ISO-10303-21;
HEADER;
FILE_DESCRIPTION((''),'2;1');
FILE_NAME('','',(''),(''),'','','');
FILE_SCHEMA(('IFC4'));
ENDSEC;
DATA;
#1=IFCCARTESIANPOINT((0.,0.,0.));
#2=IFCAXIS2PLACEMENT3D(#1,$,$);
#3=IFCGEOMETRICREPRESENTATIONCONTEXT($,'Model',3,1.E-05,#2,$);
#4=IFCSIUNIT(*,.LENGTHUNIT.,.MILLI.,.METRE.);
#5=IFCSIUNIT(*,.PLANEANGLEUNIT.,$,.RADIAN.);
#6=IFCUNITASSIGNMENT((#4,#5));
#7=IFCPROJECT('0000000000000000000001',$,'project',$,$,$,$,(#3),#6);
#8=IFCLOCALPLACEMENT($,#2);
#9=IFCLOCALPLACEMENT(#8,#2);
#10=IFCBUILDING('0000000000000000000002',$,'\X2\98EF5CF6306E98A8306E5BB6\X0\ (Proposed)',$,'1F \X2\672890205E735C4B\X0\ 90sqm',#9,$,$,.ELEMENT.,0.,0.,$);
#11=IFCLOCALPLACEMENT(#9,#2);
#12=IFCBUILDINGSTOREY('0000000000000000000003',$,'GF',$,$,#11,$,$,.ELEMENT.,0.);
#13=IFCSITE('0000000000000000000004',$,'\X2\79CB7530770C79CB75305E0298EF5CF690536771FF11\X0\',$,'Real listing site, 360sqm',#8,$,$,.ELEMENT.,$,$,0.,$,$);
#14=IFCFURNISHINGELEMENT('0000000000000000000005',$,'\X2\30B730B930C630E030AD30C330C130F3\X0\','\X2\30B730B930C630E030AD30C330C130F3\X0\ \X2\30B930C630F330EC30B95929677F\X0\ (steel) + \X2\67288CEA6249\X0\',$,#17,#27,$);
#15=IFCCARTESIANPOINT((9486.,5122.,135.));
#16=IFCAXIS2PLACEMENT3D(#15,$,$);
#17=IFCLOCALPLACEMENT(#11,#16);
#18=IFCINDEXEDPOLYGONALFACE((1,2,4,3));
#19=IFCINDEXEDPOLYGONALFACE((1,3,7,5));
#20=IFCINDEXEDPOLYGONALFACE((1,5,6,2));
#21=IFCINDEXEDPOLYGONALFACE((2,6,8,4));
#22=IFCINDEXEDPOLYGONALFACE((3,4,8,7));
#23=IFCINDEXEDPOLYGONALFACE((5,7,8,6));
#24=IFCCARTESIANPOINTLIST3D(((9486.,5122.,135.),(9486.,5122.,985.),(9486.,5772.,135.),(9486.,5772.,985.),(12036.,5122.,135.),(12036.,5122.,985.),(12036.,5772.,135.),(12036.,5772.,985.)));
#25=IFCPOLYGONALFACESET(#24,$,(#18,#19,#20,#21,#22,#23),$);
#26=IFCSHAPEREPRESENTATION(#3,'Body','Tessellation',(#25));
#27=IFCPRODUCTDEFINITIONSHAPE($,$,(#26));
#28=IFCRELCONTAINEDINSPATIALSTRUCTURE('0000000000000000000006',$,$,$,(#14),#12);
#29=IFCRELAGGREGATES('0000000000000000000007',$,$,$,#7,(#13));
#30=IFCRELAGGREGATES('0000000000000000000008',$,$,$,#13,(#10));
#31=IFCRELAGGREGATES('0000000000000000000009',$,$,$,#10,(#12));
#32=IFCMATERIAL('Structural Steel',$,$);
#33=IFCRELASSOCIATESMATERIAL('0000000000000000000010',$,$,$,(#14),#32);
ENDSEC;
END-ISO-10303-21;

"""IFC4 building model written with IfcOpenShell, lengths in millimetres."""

from ifc_helpers import new_model, si_unit, frame, frame_2d, origin, place, context, project, spatial, rectangle, extrude, material, element, save


model = new_model("IFC4")

# Units and contexts
model_context = context("Model", 3, precision=1e-05, world=origin())
ifc_project = project(units=[si_unit("LENGTHUNIT", "METRE", prefix="MILLI"), si_unit("PLANEANGLEUNIT", "RADIAN")], contexts=[model_context])

# Site, building, storey
site_placement = place(None, origin())
site = spatial("IfcSite", under=ifc_project, at=site_placement, Name="秋田県秋田市飯島道東１", ObjectType="Real listing site, 360sqm", CompositionType="ELEMENT", RefElevation=0.0)
building_placement = place(site_placement, origin())
building = spatial("IfcBuilding", under=site, at=building_placement, Name="飯島の風の家 (Proposed)", ObjectType="1F 木造平屋 90sqm", CompositionType="ELEMENT", ElevationOfRefHeight=0.0, ElevationOfTerrain=0.0)
storey_placement = place(building_placement, origin())
storey = spatial("IfcBuildingStorey", under=building, at=storey_placement, Name="GF", CompositionType="ELEMENT", Elevation=0.0)

# Shared definitions
ifc_material_1 = material(Name="Structural Steel")

# Furnishing element
furnishing_1_placement = place(storey_placement, frame((9486.0, 5122.0, 135.0)))
element("IfcFurnishingElement", 1, at=furnishing_1_placement, inside=storey, material=ifc_material_1, Name="システムキッチン", Description="システムキッチン ステンレス天板 (steel) + 木質扉", context=model_context, shape_type="SweptSolid", body=[
    extrude(rectangle(XDim=2550.0, YDim=650.0, at=frame_2d((1275.0, 325.0))), frame((9486.0, 5122.0, 135.0)), (0.0, 0.0, 1.0), 850.0),
])

save(model, "model.ifc")
